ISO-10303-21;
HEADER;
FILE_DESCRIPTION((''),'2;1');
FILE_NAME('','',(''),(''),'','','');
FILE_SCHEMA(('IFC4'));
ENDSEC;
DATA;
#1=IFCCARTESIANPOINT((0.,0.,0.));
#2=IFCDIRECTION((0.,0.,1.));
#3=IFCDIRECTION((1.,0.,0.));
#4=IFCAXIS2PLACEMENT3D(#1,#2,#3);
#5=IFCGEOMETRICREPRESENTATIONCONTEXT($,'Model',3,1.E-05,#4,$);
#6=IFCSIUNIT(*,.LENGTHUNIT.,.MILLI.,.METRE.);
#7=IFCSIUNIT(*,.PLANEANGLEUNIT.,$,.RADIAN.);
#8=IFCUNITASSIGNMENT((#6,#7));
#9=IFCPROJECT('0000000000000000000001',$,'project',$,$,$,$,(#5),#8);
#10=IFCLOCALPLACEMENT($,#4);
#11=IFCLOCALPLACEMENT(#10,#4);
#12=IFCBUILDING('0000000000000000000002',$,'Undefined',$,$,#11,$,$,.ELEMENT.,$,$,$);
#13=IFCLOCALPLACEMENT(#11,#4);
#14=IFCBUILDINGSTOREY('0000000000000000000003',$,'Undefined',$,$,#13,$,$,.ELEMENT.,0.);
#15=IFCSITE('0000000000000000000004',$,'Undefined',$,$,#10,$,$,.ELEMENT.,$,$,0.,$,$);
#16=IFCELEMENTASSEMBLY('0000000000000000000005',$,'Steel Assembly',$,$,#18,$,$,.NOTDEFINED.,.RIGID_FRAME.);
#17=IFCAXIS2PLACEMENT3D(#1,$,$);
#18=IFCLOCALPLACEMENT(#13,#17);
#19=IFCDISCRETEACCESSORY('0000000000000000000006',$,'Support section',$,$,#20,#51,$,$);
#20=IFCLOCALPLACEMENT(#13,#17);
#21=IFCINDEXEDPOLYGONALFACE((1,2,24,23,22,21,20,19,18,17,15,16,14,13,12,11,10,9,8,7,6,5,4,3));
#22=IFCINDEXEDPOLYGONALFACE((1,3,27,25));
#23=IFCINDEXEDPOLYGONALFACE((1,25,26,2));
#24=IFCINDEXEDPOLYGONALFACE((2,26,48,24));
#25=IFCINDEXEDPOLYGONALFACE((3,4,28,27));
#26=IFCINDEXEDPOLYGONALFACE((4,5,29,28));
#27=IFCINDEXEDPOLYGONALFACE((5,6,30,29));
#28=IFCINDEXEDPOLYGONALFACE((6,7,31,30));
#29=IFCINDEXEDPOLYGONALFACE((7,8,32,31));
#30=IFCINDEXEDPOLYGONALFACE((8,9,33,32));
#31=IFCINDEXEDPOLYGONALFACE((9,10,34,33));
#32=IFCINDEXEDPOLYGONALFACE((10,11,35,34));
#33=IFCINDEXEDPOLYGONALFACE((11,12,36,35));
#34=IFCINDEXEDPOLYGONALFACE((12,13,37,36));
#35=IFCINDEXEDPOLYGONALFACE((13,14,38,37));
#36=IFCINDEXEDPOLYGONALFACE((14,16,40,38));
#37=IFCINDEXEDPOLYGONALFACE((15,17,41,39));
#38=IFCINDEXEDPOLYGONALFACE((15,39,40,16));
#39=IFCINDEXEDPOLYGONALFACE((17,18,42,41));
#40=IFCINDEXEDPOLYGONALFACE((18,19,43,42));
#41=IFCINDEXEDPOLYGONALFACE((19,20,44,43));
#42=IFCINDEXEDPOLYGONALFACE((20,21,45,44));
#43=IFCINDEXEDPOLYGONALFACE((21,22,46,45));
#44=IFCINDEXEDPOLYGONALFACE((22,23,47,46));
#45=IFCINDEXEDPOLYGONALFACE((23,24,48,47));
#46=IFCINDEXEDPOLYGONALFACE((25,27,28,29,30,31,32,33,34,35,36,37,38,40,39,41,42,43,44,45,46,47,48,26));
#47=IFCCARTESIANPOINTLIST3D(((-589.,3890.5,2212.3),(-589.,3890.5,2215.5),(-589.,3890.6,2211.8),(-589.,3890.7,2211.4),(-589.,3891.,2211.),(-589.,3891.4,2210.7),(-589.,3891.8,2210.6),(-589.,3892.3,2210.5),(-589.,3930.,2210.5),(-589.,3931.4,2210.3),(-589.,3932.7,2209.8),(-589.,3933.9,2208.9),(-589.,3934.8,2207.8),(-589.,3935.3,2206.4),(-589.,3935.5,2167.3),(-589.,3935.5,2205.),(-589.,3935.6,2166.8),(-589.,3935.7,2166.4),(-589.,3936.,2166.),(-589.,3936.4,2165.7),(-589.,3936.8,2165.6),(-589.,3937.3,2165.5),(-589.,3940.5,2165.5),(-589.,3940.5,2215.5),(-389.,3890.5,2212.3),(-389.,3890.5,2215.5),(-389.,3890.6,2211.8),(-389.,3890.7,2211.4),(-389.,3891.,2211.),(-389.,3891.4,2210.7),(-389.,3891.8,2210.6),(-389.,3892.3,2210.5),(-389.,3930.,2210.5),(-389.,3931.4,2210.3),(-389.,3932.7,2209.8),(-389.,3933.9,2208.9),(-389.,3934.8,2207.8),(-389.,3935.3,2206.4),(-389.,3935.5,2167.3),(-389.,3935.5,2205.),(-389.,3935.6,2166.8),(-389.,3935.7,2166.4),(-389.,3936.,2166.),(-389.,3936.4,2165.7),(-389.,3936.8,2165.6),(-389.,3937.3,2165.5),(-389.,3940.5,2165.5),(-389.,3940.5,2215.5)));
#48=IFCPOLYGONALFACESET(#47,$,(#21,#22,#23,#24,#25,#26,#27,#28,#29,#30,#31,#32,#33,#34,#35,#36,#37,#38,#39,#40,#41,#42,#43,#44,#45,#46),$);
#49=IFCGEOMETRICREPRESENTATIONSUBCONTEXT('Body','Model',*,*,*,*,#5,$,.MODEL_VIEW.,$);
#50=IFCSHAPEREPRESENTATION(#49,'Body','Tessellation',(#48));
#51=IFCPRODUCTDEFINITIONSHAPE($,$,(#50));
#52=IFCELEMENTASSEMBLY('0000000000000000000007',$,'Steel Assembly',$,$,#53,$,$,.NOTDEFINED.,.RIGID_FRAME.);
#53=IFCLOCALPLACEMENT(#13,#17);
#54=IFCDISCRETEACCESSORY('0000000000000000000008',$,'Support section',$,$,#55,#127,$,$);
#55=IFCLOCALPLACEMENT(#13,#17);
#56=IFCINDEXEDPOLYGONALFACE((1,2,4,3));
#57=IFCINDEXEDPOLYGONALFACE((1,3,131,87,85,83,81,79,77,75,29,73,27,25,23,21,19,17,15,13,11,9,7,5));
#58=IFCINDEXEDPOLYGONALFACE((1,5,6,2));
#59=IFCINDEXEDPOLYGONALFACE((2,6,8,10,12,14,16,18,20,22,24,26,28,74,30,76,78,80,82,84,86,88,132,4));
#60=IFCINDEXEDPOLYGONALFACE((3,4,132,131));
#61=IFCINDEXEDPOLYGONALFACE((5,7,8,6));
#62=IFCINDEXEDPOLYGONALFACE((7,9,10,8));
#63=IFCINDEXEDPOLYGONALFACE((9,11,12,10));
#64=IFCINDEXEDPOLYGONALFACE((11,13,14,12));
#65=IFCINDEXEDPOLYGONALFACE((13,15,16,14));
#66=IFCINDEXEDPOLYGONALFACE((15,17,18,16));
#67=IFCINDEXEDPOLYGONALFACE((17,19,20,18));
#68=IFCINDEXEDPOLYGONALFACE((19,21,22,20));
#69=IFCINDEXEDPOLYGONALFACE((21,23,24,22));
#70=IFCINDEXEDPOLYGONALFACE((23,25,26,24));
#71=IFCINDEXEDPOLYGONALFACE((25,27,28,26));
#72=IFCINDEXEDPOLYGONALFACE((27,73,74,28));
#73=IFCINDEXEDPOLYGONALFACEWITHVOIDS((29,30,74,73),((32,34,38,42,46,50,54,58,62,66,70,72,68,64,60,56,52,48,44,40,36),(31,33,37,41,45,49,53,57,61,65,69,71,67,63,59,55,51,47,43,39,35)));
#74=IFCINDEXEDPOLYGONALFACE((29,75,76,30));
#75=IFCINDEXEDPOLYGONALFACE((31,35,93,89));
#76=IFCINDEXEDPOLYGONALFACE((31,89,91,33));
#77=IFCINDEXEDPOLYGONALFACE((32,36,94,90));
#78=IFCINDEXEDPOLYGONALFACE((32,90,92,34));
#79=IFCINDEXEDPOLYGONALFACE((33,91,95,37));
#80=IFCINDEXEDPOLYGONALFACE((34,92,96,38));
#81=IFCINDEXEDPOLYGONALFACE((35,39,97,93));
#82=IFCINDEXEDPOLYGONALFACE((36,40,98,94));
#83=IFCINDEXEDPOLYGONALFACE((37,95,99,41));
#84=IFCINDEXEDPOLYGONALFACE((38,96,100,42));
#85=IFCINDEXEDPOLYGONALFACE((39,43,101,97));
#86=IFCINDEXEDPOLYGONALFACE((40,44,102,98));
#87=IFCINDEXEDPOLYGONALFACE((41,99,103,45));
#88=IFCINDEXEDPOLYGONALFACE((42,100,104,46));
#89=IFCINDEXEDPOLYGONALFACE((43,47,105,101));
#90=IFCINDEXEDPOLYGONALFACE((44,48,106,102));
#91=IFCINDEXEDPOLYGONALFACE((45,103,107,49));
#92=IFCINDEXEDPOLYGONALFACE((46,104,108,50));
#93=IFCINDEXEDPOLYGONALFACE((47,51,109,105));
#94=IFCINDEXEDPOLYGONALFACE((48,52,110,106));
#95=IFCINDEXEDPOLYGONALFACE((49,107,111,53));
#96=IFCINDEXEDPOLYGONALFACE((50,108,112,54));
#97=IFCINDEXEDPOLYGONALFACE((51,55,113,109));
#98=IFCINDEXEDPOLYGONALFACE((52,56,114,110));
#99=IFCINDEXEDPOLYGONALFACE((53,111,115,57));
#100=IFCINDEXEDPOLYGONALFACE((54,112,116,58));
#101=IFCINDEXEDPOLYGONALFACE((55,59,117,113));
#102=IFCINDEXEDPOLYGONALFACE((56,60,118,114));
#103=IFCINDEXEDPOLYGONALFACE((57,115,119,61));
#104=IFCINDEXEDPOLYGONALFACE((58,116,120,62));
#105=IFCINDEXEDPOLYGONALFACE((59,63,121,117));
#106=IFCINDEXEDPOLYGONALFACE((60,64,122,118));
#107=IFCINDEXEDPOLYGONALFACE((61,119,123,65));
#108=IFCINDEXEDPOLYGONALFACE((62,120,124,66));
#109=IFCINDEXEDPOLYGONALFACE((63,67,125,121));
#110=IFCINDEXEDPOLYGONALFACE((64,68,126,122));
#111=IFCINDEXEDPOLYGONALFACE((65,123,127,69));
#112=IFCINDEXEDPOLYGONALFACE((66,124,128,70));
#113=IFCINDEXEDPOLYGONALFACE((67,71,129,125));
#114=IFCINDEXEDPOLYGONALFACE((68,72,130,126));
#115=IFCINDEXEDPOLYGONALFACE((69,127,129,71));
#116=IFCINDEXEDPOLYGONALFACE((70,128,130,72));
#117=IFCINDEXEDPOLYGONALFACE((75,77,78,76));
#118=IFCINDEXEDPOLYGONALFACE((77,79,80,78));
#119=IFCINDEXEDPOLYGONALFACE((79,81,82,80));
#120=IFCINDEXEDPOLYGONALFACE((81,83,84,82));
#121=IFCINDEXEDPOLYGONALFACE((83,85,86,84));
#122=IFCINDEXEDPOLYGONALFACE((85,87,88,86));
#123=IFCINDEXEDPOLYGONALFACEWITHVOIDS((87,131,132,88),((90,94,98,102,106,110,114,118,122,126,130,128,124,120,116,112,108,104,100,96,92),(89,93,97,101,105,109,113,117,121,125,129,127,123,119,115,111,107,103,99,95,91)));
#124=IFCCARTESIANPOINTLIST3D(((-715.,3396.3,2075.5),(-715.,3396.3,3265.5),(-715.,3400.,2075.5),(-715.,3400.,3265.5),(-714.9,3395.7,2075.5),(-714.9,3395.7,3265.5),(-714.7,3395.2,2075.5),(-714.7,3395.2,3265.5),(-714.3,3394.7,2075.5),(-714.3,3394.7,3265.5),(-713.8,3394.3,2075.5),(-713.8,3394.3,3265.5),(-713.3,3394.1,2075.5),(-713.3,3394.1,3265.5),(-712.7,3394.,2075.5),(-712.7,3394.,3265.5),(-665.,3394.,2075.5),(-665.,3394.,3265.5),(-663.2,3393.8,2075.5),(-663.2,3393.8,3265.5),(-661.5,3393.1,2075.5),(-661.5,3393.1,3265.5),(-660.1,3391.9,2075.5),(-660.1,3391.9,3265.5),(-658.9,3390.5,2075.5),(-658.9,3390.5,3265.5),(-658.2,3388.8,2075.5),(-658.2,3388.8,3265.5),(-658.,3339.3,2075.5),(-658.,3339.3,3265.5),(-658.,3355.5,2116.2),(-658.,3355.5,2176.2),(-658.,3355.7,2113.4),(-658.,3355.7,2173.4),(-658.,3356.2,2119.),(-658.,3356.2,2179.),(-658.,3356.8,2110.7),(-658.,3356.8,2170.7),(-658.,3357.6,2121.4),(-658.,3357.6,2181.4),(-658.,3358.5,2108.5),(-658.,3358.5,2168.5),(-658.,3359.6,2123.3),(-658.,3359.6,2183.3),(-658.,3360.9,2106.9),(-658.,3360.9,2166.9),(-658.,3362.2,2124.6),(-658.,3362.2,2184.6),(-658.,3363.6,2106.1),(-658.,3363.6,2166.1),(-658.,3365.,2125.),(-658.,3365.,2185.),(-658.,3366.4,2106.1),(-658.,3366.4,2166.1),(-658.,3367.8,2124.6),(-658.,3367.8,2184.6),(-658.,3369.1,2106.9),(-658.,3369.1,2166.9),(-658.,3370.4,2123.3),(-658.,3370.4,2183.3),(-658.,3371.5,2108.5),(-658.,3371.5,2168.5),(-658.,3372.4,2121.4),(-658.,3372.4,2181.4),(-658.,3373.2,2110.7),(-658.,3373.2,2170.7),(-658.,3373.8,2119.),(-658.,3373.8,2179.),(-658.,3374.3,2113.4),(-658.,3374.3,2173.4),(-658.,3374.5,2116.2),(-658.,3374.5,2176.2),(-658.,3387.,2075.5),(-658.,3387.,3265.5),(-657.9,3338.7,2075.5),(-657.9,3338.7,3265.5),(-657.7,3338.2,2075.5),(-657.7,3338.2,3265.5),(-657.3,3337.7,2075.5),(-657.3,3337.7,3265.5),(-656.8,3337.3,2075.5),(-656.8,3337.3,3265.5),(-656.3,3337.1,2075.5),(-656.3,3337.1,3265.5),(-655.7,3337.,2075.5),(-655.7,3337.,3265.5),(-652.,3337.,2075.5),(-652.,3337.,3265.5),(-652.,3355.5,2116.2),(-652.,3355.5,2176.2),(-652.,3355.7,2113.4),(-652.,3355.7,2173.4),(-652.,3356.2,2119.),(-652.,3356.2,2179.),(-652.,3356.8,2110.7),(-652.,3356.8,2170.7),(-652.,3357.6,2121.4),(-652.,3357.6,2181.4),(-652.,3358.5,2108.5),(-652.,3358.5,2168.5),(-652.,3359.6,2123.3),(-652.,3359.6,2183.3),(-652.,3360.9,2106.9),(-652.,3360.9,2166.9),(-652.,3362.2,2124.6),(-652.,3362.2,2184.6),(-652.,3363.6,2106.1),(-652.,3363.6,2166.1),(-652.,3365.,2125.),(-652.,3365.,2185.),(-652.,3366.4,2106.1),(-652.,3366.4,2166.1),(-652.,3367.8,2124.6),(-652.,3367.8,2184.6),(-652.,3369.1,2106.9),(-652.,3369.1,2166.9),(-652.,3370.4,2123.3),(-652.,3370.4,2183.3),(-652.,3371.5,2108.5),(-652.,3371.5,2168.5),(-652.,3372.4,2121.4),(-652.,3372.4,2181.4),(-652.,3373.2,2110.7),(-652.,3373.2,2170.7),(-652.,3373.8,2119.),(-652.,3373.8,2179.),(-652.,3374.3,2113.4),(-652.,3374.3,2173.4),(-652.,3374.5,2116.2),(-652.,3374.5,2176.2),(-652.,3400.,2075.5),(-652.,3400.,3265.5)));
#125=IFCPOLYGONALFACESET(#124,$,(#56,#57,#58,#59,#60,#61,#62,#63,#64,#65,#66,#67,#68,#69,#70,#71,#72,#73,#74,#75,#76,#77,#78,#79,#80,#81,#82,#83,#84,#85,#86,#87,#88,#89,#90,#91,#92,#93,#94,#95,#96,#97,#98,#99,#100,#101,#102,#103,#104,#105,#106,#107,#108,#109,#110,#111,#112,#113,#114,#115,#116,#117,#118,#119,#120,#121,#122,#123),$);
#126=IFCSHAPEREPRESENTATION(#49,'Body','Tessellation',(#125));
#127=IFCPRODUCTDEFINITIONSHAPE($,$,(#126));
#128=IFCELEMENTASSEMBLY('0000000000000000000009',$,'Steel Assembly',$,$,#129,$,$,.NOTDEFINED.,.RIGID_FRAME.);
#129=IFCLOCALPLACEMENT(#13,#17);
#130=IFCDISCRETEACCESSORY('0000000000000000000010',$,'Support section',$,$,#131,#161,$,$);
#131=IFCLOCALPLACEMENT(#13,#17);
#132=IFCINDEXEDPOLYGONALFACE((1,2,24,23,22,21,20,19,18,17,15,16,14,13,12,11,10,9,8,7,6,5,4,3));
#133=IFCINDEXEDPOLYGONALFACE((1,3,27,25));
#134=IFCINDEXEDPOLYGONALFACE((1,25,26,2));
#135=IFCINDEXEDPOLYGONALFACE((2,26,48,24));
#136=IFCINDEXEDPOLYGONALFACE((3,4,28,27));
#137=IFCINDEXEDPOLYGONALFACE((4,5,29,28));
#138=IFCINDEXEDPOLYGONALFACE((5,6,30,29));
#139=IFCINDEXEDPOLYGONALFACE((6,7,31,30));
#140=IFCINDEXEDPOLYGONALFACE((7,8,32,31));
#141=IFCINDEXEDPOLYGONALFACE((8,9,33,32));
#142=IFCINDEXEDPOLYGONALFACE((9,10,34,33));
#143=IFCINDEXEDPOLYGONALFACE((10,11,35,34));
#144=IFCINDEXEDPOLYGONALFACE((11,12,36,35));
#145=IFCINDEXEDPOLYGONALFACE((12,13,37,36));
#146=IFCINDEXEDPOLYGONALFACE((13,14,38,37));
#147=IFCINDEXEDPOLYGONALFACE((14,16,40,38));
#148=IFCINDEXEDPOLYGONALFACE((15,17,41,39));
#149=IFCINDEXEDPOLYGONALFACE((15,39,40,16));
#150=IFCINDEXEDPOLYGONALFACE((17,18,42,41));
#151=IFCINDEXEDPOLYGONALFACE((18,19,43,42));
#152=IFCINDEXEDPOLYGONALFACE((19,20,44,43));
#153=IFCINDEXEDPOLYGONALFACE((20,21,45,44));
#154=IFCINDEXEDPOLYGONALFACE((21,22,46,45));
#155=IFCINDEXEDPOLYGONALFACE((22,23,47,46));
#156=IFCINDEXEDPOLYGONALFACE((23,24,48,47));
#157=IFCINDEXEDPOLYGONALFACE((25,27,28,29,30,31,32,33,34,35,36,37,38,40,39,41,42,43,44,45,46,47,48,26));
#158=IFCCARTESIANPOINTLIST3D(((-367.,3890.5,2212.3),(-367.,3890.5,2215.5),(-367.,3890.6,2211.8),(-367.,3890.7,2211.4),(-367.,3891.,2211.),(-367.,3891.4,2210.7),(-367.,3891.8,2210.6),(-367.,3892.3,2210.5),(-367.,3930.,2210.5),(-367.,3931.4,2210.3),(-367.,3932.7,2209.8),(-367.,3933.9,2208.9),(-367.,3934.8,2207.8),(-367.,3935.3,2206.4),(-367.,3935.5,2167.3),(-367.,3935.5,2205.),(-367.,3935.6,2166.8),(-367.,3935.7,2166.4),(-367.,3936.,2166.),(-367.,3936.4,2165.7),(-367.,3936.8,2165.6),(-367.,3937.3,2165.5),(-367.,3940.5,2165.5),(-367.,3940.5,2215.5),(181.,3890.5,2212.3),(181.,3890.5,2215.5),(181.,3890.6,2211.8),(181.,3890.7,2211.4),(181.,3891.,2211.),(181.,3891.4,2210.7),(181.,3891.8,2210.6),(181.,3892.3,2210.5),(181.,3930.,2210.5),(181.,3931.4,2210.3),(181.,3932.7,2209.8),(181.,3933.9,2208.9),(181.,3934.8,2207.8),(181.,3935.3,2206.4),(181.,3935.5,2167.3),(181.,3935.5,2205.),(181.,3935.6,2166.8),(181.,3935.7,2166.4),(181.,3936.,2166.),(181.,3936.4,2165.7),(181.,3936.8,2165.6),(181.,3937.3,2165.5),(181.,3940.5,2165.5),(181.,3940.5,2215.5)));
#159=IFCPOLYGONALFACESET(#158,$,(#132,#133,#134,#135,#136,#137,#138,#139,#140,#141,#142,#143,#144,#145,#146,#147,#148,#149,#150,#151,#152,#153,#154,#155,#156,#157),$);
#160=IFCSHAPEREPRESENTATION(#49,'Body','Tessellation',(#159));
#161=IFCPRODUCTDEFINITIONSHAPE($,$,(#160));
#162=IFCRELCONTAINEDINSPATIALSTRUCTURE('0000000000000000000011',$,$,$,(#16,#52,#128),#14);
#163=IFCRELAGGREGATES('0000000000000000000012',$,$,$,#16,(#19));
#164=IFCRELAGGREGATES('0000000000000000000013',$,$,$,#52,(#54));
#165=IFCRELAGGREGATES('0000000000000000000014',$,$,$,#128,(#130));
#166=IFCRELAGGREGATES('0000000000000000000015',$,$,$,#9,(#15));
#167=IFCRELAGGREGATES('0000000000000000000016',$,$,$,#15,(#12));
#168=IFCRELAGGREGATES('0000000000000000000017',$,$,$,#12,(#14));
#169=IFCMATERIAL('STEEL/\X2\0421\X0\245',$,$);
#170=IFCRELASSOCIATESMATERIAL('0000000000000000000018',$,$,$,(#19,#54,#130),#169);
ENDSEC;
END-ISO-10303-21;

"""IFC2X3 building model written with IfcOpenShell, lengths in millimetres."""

from ifc_helpers import new_model, si_unit, frame, origin_with_axes, origin_2d_with_axis, place, context, subcontext, project, spatial, circle, l_section, extrude, source, transform, mapped, material, element, aggregate, save


model = new_model("IFC2X3")

# Units and contexts
model_context = context("Model", 3, precision=1e-05, world=origin_with_axes())
body_context = subcontext(model_context, "Body", "Model", "MODEL_VIEW")
ifc_project = project(units=[si_unit("LENGTHUNIT", "METRE", prefix="MILLI"), si_unit("PLANEANGLEUNIT", "RADIAN")], contexts=[model_context])

# Site, building, storey
site_placement = place(None, origin_with_axes())
site = spatial("IfcSite", under=ifc_project, at=site_placement, Name="Undefined", CompositionType="ELEMENT", RefElevation=0.0)
building_placement = place(site_placement, origin_with_axes())
building = spatial("IfcBuilding", under=site, at=building_placement, Name="Undefined", CompositionType="ELEMENT")
storey_placement = place(building_placement, origin_with_axes())
storey = spatial("IfcBuildingStorey", under=building, at=storey_placement, Name="Undefined", CompositionType="ELEMENT", Elevation=0.0)

# Shared definitions
ifc_material_1 = material(Name="STEEL/С245")
shared_shape_1 = source(origin_with_axes(), body_context, "Body", "SweptSolid", [
    extrude(circle(Radius=9.5, at=origin_2d_with_axis()), frame((0.0, -0.1, 0.0), z_axis=(0.0, 1.0, 0.0), x_axis=(1.0, 0.0, 0.0)), (0.0, 0.0, 1.0), 6.2),
])

# Element assembly, discrete accessory
assembly_1_placement = place(storey_placement, origin_with_axes())
assembly_1 = element("IfcElementAssembly", 1, at=assembly_1_placement, inside=storey, Name="Steel Assembly", AssemblyPlace="NOTDEFINED", PredefinedType="RIGID_FRAME")
discrete_accessory_1_placement = place(assembly_1_placement, frame((-589.0, 3915.5, 2190.5), z_axis=(0.0, -1.0, 0.0), x_axis=(1.0, 0.0, 0.0)))
discrete_accessory_1 = element("IfcDiscreteAccessory", 2, at=discrete_accessory_1_placement, material=ifc_material_1, Name="Support section", context=body_context, shape_type="SweptSolid", body=[
    extrude(l_section(Depth=50.0, Width=50.0, Thickness=5.0, FilletRadius=5.5, EdgeRadius=1.8, at=origin_2d_with_axis()), frame((200.0, 0.0, 0.0), z_axis=(-1.0, 0.0, 0.0), x_axis=(0.0, -1.0, 0.0)), (0.0, 0.0, 1.0), 200.0),
])
aggregate(assembly_1, [discrete_accessory_1])

# Element assembly, discrete accessory, opening
assembly_2_placement = place(storey_placement, origin_with_axes())
assembly_2 = element("IfcElementAssembly", 3, at=assembly_2_placement, inside=storey, Name="Steel Assembly", AssemblyPlace="NOTDEFINED", PredefinedType="RIGID_FRAME")
discrete_accessory_2_placement = place(assembly_2_placement, frame((-683.5, 3368.5, 2075.5), z_axis=(0.0, 0.0, 1.0), x_axis=(1.0, 0.0, 0.0)))
discrete_accessory_2 = element("IfcDiscreteAccessory", 4, at=discrete_accessory_2_placement, material=ifc_material_1, Name="Support section", context=body_context, shape_type="SweptSolid", body=[
    extrude(l_section(Depth=63.0, Width=63.0, Thickness=6.0, FilletRadius=7.0, EdgeRadius=2.3, at=origin_2d_with_axis()), frame((0.0, 0.0, 1190.0), z_axis=(0.0, 0.0, -1.0), x_axis=(0.0, -1.0, 0.0)), (0.0, 0.0, 1.0), 1190.0),
])
opening_1_placement = place(assembly_2_placement, frame((-652.0, 3365.0, 2115.5), z_axis=(0.0, -1.0, 0.0), x_axis=(0.0, 0.0, 1.0)))
element("IfcOpeningElement", 5, at=opening_1_placement, cuts=discrete_accessory_2, ObjectType="Opening", context=body_context, shape_type="MappedRepresentation", body=[
    mapped(shared_shape_1, transform((0.0, 0.0, 0.0))),
    mapped(shared_shape_1, transform((60.0, 0.0, 0.0))),
])
aggregate(assembly_2, [discrete_accessory_2])

# Element assembly, discrete accessory
assembly_3_placement = place(storey_placement, origin_with_axes())
assembly_3 = element("IfcElementAssembly", 6, at=assembly_3_placement, inside=storey, Name="Steel Assembly", AssemblyPlace="NOTDEFINED", PredefinedType="RIGID_FRAME")
discrete_accessory_3_placement = place(assembly_3_placement, frame((-367.0, 3915.5, 2190.5), z_axis=(0.0, -1.0, 0.0), x_axis=(1.0, 0.0, 0.0)))
discrete_accessory_3 = element("IfcDiscreteAccessory", 7, at=discrete_accessory_3_placement, material=ifc_material_1, Name="Support section", context=body_context, shape_type="SweptSolid", body=[
    extrude(l_section(Depth=50.0, Width=50.0, Thickness=5.0, FilletRadius=5.5, EdgeRadius=1.8, at=origin_2d_with_axis()), frame((548.0, 0.0, 0.0), z_axis=(-1.0, 0.0, 0.0), x_axis=(0.0, -1.0, 0.0)), (0.0, 0.0, 1.0), 548.0),
])
aggregate(assembly_3, [discrete_accessory_3])

save(model, "model.ifc")
